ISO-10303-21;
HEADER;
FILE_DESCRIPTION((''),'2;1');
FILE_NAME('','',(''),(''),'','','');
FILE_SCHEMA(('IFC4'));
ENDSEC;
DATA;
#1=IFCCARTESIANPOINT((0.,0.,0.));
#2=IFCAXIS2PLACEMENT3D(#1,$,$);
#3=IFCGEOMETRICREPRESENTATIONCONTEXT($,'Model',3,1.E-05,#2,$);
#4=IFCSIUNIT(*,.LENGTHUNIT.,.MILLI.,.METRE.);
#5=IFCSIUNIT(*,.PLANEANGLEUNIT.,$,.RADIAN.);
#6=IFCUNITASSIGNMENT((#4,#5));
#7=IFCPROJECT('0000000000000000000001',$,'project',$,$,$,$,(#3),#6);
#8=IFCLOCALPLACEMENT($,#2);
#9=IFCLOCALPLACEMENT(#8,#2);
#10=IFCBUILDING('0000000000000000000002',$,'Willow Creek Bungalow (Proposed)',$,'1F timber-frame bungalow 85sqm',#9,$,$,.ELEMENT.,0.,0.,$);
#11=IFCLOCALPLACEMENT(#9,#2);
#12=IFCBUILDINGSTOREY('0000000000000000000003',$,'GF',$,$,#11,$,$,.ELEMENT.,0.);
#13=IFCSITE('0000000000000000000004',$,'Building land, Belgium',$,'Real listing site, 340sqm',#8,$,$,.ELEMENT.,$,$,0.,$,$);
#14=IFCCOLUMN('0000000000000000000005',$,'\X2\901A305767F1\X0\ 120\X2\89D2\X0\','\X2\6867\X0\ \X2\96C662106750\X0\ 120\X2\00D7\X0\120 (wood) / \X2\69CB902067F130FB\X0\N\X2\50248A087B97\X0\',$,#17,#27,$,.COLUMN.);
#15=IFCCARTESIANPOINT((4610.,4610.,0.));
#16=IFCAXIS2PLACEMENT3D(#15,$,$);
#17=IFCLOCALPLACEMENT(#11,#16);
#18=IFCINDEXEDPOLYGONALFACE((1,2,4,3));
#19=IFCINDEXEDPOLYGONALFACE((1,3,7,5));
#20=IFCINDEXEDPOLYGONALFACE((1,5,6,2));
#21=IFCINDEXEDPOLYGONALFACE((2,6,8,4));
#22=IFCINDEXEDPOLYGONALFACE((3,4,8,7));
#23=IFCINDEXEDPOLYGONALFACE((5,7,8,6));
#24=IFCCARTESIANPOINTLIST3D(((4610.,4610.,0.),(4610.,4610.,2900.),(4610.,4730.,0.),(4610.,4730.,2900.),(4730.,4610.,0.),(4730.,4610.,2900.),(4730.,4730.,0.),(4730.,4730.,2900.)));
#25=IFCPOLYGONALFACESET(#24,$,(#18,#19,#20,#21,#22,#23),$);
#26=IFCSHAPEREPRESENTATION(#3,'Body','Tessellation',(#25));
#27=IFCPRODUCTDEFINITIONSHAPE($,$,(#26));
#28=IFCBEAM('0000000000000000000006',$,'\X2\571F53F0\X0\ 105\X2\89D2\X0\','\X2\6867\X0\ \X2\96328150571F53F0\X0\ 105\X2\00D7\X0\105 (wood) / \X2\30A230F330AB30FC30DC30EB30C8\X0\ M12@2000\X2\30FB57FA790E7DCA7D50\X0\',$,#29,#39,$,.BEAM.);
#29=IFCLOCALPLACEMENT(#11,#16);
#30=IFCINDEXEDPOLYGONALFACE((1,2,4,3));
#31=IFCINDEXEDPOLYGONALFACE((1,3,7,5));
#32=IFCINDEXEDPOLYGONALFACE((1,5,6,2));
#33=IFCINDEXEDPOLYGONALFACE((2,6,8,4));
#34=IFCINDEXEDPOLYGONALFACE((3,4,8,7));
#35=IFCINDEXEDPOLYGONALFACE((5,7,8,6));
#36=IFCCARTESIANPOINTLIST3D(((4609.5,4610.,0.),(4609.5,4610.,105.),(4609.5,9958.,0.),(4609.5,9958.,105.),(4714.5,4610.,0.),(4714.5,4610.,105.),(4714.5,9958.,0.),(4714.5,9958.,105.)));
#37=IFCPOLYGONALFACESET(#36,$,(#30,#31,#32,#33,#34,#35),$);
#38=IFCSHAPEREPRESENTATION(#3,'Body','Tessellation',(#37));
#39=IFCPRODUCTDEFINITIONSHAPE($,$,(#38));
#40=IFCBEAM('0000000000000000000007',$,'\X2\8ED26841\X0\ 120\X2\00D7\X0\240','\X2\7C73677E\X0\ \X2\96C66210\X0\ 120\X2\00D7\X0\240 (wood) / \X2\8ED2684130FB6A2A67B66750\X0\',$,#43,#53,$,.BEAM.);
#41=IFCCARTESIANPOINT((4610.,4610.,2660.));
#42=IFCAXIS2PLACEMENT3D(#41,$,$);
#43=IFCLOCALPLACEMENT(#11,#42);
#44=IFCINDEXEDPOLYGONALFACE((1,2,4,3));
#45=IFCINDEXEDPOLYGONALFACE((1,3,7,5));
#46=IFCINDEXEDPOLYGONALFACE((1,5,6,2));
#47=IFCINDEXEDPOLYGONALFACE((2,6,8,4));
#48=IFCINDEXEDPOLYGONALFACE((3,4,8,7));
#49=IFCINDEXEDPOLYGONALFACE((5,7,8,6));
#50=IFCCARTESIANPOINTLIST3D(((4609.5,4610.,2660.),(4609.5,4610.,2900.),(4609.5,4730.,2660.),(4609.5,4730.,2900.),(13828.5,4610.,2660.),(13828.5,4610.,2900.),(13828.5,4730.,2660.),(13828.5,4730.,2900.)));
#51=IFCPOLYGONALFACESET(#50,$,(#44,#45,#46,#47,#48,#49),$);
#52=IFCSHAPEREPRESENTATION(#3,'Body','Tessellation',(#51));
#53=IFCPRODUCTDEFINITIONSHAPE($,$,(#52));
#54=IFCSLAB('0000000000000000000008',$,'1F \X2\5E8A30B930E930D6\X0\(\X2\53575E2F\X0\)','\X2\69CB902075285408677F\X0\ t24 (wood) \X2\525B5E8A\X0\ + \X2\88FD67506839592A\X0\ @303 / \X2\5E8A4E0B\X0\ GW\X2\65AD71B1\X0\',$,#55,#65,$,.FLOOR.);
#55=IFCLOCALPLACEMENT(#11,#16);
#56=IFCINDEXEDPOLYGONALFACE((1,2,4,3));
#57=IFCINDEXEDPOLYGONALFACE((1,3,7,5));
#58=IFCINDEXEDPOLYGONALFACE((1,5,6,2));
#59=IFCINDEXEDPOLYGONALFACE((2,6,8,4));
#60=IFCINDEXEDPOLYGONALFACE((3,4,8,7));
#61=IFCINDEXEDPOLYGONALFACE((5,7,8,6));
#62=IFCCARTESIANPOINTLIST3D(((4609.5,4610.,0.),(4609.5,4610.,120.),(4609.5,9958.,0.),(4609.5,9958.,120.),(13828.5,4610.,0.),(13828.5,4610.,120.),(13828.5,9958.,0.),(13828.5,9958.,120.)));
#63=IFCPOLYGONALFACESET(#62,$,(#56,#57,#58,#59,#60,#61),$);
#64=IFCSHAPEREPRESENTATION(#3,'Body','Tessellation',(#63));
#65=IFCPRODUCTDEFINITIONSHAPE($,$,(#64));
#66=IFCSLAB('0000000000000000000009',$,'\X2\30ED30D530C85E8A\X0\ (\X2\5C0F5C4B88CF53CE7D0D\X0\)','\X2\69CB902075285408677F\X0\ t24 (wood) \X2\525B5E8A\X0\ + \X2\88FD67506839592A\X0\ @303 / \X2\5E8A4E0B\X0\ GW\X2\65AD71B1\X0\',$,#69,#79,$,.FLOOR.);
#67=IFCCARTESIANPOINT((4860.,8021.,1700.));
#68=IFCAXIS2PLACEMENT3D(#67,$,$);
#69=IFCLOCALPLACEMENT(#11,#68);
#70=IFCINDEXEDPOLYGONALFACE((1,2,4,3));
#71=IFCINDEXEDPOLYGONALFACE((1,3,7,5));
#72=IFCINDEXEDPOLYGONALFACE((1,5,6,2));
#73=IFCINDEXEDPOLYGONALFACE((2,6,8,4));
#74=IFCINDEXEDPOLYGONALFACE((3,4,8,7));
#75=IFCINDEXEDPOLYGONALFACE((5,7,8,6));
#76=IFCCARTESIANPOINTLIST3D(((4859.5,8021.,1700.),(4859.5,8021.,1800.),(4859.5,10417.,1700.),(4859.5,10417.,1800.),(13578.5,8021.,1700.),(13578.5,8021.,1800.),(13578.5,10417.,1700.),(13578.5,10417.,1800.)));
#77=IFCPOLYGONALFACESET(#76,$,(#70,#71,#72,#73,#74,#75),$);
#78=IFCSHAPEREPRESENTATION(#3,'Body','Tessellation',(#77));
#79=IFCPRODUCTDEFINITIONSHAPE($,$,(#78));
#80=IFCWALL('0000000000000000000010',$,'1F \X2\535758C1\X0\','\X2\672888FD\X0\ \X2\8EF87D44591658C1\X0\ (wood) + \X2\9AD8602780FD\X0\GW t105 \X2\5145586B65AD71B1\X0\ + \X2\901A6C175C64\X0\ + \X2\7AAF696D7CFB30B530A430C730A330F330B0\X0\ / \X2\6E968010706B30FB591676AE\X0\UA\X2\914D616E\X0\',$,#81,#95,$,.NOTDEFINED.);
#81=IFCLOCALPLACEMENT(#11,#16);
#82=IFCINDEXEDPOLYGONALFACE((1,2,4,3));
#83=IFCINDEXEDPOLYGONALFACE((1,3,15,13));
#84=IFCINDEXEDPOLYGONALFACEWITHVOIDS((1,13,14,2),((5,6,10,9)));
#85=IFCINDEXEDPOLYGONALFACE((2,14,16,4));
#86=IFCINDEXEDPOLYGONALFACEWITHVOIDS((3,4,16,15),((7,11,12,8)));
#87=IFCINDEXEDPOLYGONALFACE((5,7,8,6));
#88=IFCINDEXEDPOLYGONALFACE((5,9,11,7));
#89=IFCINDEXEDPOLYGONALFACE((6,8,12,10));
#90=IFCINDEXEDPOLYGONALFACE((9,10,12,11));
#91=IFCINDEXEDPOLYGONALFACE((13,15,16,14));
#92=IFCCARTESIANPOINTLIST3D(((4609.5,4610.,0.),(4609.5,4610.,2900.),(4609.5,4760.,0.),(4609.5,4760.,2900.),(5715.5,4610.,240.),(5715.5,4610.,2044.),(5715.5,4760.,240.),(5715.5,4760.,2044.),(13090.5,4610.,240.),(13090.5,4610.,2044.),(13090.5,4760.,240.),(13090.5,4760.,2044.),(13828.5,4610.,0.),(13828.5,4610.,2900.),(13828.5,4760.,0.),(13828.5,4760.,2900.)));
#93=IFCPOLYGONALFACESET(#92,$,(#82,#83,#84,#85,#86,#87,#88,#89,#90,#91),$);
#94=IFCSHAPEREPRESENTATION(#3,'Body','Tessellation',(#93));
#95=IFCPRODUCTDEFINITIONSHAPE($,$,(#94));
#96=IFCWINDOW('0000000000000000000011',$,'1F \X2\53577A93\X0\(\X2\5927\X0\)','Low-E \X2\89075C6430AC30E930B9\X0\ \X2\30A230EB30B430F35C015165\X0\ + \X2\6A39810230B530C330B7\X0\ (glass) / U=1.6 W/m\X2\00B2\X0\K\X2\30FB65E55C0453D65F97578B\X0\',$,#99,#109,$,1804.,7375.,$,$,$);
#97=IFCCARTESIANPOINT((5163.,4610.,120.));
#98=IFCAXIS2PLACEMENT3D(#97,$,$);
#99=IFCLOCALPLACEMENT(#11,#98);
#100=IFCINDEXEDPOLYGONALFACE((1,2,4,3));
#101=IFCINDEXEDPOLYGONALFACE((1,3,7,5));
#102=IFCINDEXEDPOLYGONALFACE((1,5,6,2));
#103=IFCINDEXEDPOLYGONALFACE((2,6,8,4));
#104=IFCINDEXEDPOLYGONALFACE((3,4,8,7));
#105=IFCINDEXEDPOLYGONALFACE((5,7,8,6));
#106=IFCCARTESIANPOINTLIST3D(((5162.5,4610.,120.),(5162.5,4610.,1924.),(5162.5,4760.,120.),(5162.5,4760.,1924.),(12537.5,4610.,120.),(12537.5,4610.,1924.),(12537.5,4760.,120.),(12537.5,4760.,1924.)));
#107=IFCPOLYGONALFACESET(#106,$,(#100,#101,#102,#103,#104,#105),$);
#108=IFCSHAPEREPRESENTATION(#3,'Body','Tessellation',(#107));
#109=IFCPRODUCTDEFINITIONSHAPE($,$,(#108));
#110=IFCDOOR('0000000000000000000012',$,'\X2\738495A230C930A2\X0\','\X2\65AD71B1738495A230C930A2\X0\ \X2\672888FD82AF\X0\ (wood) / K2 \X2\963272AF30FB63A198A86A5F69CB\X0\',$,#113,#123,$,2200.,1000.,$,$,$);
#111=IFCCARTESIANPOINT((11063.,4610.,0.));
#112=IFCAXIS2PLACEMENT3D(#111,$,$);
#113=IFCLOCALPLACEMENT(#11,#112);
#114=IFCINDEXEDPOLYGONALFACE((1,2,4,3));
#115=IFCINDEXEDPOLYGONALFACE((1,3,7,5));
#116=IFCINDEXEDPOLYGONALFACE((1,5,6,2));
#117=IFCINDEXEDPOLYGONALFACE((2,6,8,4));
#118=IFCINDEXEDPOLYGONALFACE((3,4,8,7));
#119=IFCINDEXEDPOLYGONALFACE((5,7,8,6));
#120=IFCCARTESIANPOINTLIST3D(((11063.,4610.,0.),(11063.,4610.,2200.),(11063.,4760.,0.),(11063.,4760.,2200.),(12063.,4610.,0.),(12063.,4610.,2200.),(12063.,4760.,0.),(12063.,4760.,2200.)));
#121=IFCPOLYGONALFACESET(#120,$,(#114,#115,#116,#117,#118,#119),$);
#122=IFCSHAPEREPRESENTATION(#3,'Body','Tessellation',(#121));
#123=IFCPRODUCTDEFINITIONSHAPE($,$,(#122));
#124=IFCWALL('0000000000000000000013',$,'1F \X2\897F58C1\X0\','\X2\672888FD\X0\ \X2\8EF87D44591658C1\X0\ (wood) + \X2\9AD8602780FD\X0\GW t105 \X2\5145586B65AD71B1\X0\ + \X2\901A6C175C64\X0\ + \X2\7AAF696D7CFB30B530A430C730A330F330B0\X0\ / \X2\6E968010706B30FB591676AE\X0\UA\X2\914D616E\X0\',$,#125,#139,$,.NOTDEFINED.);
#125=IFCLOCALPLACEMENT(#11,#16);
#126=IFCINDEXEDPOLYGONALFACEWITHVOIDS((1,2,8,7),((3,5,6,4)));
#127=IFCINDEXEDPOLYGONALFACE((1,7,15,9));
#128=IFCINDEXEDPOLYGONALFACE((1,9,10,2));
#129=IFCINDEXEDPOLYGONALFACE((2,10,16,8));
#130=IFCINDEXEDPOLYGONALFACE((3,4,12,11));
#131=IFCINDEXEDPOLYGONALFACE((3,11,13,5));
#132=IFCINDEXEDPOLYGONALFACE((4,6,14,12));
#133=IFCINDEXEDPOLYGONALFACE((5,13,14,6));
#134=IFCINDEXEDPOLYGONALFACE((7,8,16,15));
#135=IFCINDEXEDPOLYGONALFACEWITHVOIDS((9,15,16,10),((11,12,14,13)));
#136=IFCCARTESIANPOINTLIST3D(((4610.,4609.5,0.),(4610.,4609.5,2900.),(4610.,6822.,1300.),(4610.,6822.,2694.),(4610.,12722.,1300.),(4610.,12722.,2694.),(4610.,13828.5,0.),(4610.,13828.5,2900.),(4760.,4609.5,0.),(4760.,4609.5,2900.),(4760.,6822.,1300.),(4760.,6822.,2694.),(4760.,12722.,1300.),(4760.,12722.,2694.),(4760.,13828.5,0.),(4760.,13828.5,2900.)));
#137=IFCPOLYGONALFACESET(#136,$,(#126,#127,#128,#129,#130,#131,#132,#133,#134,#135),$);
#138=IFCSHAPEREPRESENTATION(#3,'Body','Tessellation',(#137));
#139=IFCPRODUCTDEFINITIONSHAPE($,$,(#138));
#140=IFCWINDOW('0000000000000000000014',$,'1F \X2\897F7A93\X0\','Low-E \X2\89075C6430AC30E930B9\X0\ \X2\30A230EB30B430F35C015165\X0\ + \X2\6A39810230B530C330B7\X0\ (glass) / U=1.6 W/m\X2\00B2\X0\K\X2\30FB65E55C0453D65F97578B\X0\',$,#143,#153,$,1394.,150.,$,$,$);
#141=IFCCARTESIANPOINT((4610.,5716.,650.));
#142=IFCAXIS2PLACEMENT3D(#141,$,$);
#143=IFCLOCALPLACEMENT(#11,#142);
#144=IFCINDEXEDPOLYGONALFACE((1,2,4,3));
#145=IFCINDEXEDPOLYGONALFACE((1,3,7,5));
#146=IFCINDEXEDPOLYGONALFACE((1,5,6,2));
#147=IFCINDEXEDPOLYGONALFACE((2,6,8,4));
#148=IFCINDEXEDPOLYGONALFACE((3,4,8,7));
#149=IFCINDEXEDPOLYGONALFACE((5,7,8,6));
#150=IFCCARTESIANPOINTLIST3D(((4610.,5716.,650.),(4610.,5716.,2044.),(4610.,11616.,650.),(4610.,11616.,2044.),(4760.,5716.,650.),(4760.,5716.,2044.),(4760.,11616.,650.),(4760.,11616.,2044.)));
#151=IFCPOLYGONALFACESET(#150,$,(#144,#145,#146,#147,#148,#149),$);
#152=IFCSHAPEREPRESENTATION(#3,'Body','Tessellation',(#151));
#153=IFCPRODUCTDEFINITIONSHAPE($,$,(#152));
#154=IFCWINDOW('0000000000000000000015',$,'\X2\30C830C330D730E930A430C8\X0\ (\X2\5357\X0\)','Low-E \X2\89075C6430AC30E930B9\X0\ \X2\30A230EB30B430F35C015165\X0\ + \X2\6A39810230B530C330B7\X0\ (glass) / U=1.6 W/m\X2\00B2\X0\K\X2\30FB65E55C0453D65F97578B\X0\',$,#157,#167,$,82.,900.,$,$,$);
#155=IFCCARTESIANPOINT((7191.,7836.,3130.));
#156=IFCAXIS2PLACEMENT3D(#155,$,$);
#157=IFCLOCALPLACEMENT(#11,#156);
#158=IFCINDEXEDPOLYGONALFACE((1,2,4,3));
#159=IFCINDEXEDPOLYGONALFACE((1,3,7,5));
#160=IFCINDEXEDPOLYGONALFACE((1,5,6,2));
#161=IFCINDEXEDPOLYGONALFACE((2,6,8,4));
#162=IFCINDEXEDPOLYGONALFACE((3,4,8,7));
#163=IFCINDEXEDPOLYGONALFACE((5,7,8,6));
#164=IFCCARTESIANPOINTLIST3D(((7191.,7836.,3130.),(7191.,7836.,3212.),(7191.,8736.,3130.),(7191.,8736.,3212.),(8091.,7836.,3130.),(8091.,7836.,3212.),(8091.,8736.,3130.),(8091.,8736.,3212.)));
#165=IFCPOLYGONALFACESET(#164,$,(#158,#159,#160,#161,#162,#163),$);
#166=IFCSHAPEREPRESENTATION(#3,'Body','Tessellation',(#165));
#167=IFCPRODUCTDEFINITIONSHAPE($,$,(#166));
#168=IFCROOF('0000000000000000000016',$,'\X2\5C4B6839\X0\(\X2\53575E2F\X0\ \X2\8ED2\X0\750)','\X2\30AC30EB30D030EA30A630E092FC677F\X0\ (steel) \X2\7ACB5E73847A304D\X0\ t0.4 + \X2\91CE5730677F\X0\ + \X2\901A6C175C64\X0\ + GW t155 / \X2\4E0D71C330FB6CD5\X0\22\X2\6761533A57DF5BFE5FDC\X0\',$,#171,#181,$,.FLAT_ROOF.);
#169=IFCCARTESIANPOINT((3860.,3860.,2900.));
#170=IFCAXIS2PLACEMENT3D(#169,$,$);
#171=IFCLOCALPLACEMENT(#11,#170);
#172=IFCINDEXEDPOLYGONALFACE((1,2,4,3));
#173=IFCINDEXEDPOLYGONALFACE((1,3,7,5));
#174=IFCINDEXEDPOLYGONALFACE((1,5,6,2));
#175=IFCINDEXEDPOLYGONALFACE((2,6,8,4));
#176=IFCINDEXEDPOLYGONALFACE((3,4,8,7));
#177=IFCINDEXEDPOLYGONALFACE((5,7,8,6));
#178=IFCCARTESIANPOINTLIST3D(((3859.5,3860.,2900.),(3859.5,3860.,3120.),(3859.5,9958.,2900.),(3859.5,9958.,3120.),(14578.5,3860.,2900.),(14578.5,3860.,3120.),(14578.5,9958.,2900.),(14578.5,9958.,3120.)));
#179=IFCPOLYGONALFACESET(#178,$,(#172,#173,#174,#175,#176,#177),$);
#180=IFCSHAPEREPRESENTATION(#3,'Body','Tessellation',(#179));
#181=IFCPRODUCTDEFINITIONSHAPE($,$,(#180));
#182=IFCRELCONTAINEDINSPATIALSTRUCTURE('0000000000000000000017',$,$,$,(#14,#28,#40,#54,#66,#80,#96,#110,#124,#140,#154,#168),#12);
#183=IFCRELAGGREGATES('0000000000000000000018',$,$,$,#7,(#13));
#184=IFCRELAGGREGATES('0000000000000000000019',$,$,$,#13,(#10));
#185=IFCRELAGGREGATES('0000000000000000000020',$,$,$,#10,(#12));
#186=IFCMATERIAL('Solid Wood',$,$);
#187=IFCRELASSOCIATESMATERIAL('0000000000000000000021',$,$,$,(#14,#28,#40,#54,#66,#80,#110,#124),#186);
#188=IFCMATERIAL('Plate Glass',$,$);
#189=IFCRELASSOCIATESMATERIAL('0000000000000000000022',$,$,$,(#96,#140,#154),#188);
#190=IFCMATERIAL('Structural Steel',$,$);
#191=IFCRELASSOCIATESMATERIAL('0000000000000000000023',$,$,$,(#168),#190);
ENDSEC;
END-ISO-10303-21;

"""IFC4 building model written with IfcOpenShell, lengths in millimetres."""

from ifc_helpers import new_model, si_unit, frame, frame_2d, origin, place, context, project, spatial, rectangle, extrude, material, element, fill, save


model = new_model("IFC4")

# Units and contexts
model_context = context("Model", 3, precision=1e-05, world=origin())
ifc_project = project(units=[si_unit("LENGTHUNIT", "METRE", prefix="MILLI"), si_unit("PLANEANGLEUNIT", "RADIAN")], contexts=[model_context])

# Site, building, storey
site_placement = place(None, origin())
site = spatial("IfcSite", under=ifc_project, at=site_placement, Name="Building land, Belgium", ObjectType="Real listing site, 340sqm", CompositionType="ELEMENT", RefElevation=0.0)
building_placement = place(site_placement, origin())
building = spatial("IfcBuilding", under=site, at=building_placement, Name="Willow Creek Bungalow (Proposed)", ObjectType="1F timber-frame bungalow 85sqm", CompositionType="ELEMENT", ElevationOfRefHeight=0.0, ElevationOfTerrain=0.0)
storey_placement = place(building_placement, origin())
storey = spatial("IfcBuildingStorey", under=building, at=storey_placement, Name="GF", CompositionType="ELEMENT", Elevation=0.0)

# Column
ifc_material_1 = material(Name="Solid Wood")
column_1_placement = place(storey_placement, frame((4610.0, 4610.0, 0.0)))
element("IfcColumn", 1, at=column_1_placement, inside=storey, material=ifc_material_1, Name="通し柱 120角", Description="桧 集成材 120×120 (wood) / 構造柱・N値計算", PredefinedType="COLUMN", context=model_context, shape_type="SweptSolid", body=[
    extrude(rectangle(XDim=120.0, YDim=120.0, at=frame_2d((60.0, 60.0))), frame((4610.0, 4610.0, 0.0)), (0.0, 0.0, 1.0), 2900.0),
])

# Beams
beam_1_placement = place(storey_placement, frame((4610.0, 4610.0, 0.0)))
element("IfcBeam", 2, at=beam_1_placement, inside=storey, material=ifc_material_1, Name="土台 105角", Description="桧 防腐土台 105×105 (wood) / アンカーボルト M12@2000・基礎緊結", PredefinedType="BEAM", context=model_context, shape_type="SweptSolid", body=[
    extrude(rectangle(XDim=105.0, YDim=5348.0, at=frame_2d((52.0, 2674.0))), frame((4610.0, 4610.0, 0.0)), (0.0, 0.0, 1.0), 105.0),
])
beam_2_placement = place(storey_placement, frame((4610.0, 4610.0, 2660.0)))
element("IfcBeam", 3, at=beam_2_placement, inside=storey, material=ifc_material_1, Name="軒桁 120×240", Description="米松 集成 120×240 (wood) / 軒桁・横架材", PredefinedType="BEAM", context=model_context, shape_type="SweptSolid", body=[
    extrude(rectangle(XDim=9219.0, YDim=120.0, at=frame_2d((4609.0, 60.0))), frame((4610.0, 4610.0, 2660.0)), (0.0, 0.0, 1.0), 240.0),
])

# Slabs
slab_1_placement = place(storey_placement, frame((4610.0, 4610.0, 0.0)))
element("IfcSlab", 4, at=slab_1_placement, inside=storey, material=ifc_material_1, Name="1F 床スラブ(南帯)", Description="構造用合板 t24 (wood) 剛床 + 製材根太 @303 / 床下 GW断熱", PredefinedType="FLOOR", context=model_context, shape_type="SweptSolid", body=[
    extrude(rectangle(XDim=9219.0, YDim=5348.0, at=frame_2d((4609.0, 2674.0))), frame((4610.0, 4610.0, 0.0)), (0.0, 0.0, 1.0), 120.0),
])
slab_2_placement = place(storey_placement, frame((4860.0, 8021.0, 1700.0)))
element("IfcSlab", 5, at=slab_2_placement, inside=storey, material=ifc_material_1, Name="ロフト床 (小屋裏収納)", Description="構造用合板 t24 (wood) 剛床 + 製材根太 @303 / 床下 GW断熱", PredefinedType="FLOOR", context=model_context, shape_type="SweptSolid", body=[
    extrude(rectangle(XDim=8719.0, YDim=2396.0, at=frame_2d((4359.0, 1198.0))), frame((4860.0, 8021.0, 1700.0)), (0.0, 0.0, 1.0), 100.0),
])

# Wall, openings, window, door
wall_1_placement = place(storey_placement, frame((4610.0, 4610.0, 0.0)))
wall_1 = element("IfcWall", 6, at=wall_1_placement, inside=storey, material=ifc_material_1, Name="1F 南壁", Description="木製 軸組外壁 (wood) + 高性能GW t105 充填断熱 + 通気層 + 窯業系サイディング / 準耐火・外皮UA配慮", PredefinedType="NOTDEFINED", context=model_context, shape_type="SweptSolid", body=[
    extrude(rectangle(XDim=9219.0, YDim=150.0, at=frame_2d((4609.0, 75.0))), frame((4610.0, 4610.0, 0.0)), (0.0, 0.0, 1.0), 2900.0),
])
opening_1_placement = place(storey_placement, frame((5163.0, 4610.0, 120.0)))
opening_1 = element("IfcOpeningElement", 7, at=opening_1_placement, cuts=wall_1, PredefinedType="NOTDEFINED", context=model_context, shape_type="SweptSolid", body=[
    extrude(rectangle(XDim=7375.0, YDim=150.0, at=frame_2d((3687.0, 75.0))), frame((5163.0, 4610.0, 120.0)), (0.0, 0.0, 1.0), 1804.0),
])
opening_2_placement = place(storey_placement, frame((11063.0, 4610.0, 0.0)))
opening_2 = element("IfcOpeningElement", 8, at=opening_2_placement, cuts=wall_1, PredefinedType="NOTDEFINED", context=model_context, shape_type="SweptSolid", body=[
    extrude(rectangle(XDim=1000.0, YDim=150.0, at=frame_2d((500.0, 75.0))), frame((11063.0, 4610.0, 0.0)), (0.0, 0.0, 1.0), 2200.0),
])
ifc_material_2 = material(Name="Plate Glass")
window_1_placement = place(storey_placement, frame((5163.0, 4610.0, 120.0)))
window_1 = element("IfcWindow", 9, at=window_1_placement, inside=storey, material=ifc_material_2, Name="1F 南窓(大)", Description="Low-E 複層ガラス アルゴン封入 + 樹脂サッシ (glass) / U=1.6 W/m²K・日射取得型", OverallHeight=1804.0, OverallWidth=7375.0, context=model_context, shape_type="SweptSolid", body=[
    extrude(rectangle(XDim=7375.0, YDim=150.0, at=frame_2d((3687.0, 75.0))), frame((5163.0, 4610.0, 120.0)), (0.0, 0.0, 1.0), 1804.0),
])
fill(opening_1, window_1)
door_1_placement = place(storey_placement, frame((11063.0, 4610.0, 0.0)))
door_1 = element("IfcDoor", 10, at=door_1_placement, inside=storey, material=ifc_material_1, Name="玄関ドア", Description="断熱玄関ドア 木製芯 (wood) / K2 防犯・採風機構", OverallHeight=2200.0, OverallWidth=1000.0, context=model_context, shape_type="SweptSolid", body=[
    extrude(rectangle(XDim=1000.0, YDim=150.0, at=frame_2d((500.0, 75.0))), frame((11063.0, 4610.0, 0.0)), (0.0, 0.0, 1.0), 2200.0),
])
fill(opening_2, door_1)

# Wall, opening, window
wall_2_placement = place(storey_placement, frame((4610.0, 4610.0, 0.0)))
wall_2 = element("IfcWall", 11, at=wall_2_placement, inside=storey, material=ifc_material_1, Name="1F 西壁", Description="木製 軸組外壁 (wood) + 高性能GW t105 充填断熱 + 通気層 + 窯業系サイディング / 準耐火・外皮UA配慮", PredefinedType="NOTDEFINED", context=model_context, shape_type="SweptSolid", body=[
    extrude(rectangle(XDim=150.0, YDim=9219.0, at=frame_2d((75.0, 4609.0))), frame((4610.0, 4610.0, 0.0)), (0.0, 0.0, 1.0), 2900.0),
])
opening_3_placement = place(storey_placement, frame((4610.0, 5716.0, 650.0)))
opening_3 = element("IfcOpeningElement", 12, at=opening_3_placement, cuts=wall_2, PredefinedType="NOTDEFINED", context=model_context, shape_type="SweptSolid", body=[
    extrude(rectangle(XDim=150.0, YDim=5900.0, at=frame_2d((75.0, 2950.0))), frame((4610.0, 5716.0, 650.0)), (0.0, 0.0, 1.0), 1394.0),
])
window_2_placement = place(storey_placement, frame((4610.0, 5716.0, 650.0)))
window_2 = element("IfcWindow", 13, at=window_2_placement, inside=storey, material=ifc_material_2, Name="1F 西窓", Description="Low-E 複層ガラス アルゴン封入 + 樹脂サッシ (glass) / U=1.6 W/m²K・日射取得型", OverallHeight=1394.0, OverallWidth=150.0, context=model_context, shape_type="SweptSolid", body=[
    extrude(rectangle(XDim=150.0, YDim=5900.0, at=frame_2d((75.0, 2950.0))), frame((4610.0, 5716.0, 650.0)), (0.0, 0.0, 1.0), 1394.0),
])
fill(opening_3, window_2)

# Window
window_3_placement = place(storey_placement, frame((7191.0, 7836.0, 3130.0)))
element("IfcWindow", 14, at=window_3_placement, inside=storey, material=ifc_material_2, Name="トップライト (南)", Description="Low-E 複層ガラス アルゴン封入 + 樹脂サッシ (glass) / U=1.6 W/m²K・日射取得型", OverallHeight=82.0, OverallWidth=900.0, context=model_context, shape_type="SweptSolid", body=[
    extrude(rectangle(XDim=900.0, YDim=900.0, at=frame_2d((450.0, 450.0))), frame((7191.0, 7836.0, 3130.0)), (0.0, 0.0, 1.0), 82.0),
])

# Roof
ifc_material_3 = material(Name="Structural Steel")
roof_placement = place(storey_placement, frame((3860.0, 3860.0, 2900.0)))
element("IfcRoof", 15, at=roof_placement, inside=storey, material=ifc_material_3, Name="屋根(南帯 軒750)", Description="ガルバリウム鋼板 (steel) 立平葺き t0.4 + 野地板 + 通気層 + GW t155 / 不燃・法22条区域対応", PredefinedType="FLAT_ROOF", context=model_context, shape_type="SweptSolid", body=[
    extrude(rectangle(XDim=10719.0, YDim=6098.0, at=frame_2d((5359.0, 3049.0))), frame((3860.0, 3860.0, 2900.0)), (0.0, 0.0, 1.0), 220.0),
])

save(model, "model.ifc")
